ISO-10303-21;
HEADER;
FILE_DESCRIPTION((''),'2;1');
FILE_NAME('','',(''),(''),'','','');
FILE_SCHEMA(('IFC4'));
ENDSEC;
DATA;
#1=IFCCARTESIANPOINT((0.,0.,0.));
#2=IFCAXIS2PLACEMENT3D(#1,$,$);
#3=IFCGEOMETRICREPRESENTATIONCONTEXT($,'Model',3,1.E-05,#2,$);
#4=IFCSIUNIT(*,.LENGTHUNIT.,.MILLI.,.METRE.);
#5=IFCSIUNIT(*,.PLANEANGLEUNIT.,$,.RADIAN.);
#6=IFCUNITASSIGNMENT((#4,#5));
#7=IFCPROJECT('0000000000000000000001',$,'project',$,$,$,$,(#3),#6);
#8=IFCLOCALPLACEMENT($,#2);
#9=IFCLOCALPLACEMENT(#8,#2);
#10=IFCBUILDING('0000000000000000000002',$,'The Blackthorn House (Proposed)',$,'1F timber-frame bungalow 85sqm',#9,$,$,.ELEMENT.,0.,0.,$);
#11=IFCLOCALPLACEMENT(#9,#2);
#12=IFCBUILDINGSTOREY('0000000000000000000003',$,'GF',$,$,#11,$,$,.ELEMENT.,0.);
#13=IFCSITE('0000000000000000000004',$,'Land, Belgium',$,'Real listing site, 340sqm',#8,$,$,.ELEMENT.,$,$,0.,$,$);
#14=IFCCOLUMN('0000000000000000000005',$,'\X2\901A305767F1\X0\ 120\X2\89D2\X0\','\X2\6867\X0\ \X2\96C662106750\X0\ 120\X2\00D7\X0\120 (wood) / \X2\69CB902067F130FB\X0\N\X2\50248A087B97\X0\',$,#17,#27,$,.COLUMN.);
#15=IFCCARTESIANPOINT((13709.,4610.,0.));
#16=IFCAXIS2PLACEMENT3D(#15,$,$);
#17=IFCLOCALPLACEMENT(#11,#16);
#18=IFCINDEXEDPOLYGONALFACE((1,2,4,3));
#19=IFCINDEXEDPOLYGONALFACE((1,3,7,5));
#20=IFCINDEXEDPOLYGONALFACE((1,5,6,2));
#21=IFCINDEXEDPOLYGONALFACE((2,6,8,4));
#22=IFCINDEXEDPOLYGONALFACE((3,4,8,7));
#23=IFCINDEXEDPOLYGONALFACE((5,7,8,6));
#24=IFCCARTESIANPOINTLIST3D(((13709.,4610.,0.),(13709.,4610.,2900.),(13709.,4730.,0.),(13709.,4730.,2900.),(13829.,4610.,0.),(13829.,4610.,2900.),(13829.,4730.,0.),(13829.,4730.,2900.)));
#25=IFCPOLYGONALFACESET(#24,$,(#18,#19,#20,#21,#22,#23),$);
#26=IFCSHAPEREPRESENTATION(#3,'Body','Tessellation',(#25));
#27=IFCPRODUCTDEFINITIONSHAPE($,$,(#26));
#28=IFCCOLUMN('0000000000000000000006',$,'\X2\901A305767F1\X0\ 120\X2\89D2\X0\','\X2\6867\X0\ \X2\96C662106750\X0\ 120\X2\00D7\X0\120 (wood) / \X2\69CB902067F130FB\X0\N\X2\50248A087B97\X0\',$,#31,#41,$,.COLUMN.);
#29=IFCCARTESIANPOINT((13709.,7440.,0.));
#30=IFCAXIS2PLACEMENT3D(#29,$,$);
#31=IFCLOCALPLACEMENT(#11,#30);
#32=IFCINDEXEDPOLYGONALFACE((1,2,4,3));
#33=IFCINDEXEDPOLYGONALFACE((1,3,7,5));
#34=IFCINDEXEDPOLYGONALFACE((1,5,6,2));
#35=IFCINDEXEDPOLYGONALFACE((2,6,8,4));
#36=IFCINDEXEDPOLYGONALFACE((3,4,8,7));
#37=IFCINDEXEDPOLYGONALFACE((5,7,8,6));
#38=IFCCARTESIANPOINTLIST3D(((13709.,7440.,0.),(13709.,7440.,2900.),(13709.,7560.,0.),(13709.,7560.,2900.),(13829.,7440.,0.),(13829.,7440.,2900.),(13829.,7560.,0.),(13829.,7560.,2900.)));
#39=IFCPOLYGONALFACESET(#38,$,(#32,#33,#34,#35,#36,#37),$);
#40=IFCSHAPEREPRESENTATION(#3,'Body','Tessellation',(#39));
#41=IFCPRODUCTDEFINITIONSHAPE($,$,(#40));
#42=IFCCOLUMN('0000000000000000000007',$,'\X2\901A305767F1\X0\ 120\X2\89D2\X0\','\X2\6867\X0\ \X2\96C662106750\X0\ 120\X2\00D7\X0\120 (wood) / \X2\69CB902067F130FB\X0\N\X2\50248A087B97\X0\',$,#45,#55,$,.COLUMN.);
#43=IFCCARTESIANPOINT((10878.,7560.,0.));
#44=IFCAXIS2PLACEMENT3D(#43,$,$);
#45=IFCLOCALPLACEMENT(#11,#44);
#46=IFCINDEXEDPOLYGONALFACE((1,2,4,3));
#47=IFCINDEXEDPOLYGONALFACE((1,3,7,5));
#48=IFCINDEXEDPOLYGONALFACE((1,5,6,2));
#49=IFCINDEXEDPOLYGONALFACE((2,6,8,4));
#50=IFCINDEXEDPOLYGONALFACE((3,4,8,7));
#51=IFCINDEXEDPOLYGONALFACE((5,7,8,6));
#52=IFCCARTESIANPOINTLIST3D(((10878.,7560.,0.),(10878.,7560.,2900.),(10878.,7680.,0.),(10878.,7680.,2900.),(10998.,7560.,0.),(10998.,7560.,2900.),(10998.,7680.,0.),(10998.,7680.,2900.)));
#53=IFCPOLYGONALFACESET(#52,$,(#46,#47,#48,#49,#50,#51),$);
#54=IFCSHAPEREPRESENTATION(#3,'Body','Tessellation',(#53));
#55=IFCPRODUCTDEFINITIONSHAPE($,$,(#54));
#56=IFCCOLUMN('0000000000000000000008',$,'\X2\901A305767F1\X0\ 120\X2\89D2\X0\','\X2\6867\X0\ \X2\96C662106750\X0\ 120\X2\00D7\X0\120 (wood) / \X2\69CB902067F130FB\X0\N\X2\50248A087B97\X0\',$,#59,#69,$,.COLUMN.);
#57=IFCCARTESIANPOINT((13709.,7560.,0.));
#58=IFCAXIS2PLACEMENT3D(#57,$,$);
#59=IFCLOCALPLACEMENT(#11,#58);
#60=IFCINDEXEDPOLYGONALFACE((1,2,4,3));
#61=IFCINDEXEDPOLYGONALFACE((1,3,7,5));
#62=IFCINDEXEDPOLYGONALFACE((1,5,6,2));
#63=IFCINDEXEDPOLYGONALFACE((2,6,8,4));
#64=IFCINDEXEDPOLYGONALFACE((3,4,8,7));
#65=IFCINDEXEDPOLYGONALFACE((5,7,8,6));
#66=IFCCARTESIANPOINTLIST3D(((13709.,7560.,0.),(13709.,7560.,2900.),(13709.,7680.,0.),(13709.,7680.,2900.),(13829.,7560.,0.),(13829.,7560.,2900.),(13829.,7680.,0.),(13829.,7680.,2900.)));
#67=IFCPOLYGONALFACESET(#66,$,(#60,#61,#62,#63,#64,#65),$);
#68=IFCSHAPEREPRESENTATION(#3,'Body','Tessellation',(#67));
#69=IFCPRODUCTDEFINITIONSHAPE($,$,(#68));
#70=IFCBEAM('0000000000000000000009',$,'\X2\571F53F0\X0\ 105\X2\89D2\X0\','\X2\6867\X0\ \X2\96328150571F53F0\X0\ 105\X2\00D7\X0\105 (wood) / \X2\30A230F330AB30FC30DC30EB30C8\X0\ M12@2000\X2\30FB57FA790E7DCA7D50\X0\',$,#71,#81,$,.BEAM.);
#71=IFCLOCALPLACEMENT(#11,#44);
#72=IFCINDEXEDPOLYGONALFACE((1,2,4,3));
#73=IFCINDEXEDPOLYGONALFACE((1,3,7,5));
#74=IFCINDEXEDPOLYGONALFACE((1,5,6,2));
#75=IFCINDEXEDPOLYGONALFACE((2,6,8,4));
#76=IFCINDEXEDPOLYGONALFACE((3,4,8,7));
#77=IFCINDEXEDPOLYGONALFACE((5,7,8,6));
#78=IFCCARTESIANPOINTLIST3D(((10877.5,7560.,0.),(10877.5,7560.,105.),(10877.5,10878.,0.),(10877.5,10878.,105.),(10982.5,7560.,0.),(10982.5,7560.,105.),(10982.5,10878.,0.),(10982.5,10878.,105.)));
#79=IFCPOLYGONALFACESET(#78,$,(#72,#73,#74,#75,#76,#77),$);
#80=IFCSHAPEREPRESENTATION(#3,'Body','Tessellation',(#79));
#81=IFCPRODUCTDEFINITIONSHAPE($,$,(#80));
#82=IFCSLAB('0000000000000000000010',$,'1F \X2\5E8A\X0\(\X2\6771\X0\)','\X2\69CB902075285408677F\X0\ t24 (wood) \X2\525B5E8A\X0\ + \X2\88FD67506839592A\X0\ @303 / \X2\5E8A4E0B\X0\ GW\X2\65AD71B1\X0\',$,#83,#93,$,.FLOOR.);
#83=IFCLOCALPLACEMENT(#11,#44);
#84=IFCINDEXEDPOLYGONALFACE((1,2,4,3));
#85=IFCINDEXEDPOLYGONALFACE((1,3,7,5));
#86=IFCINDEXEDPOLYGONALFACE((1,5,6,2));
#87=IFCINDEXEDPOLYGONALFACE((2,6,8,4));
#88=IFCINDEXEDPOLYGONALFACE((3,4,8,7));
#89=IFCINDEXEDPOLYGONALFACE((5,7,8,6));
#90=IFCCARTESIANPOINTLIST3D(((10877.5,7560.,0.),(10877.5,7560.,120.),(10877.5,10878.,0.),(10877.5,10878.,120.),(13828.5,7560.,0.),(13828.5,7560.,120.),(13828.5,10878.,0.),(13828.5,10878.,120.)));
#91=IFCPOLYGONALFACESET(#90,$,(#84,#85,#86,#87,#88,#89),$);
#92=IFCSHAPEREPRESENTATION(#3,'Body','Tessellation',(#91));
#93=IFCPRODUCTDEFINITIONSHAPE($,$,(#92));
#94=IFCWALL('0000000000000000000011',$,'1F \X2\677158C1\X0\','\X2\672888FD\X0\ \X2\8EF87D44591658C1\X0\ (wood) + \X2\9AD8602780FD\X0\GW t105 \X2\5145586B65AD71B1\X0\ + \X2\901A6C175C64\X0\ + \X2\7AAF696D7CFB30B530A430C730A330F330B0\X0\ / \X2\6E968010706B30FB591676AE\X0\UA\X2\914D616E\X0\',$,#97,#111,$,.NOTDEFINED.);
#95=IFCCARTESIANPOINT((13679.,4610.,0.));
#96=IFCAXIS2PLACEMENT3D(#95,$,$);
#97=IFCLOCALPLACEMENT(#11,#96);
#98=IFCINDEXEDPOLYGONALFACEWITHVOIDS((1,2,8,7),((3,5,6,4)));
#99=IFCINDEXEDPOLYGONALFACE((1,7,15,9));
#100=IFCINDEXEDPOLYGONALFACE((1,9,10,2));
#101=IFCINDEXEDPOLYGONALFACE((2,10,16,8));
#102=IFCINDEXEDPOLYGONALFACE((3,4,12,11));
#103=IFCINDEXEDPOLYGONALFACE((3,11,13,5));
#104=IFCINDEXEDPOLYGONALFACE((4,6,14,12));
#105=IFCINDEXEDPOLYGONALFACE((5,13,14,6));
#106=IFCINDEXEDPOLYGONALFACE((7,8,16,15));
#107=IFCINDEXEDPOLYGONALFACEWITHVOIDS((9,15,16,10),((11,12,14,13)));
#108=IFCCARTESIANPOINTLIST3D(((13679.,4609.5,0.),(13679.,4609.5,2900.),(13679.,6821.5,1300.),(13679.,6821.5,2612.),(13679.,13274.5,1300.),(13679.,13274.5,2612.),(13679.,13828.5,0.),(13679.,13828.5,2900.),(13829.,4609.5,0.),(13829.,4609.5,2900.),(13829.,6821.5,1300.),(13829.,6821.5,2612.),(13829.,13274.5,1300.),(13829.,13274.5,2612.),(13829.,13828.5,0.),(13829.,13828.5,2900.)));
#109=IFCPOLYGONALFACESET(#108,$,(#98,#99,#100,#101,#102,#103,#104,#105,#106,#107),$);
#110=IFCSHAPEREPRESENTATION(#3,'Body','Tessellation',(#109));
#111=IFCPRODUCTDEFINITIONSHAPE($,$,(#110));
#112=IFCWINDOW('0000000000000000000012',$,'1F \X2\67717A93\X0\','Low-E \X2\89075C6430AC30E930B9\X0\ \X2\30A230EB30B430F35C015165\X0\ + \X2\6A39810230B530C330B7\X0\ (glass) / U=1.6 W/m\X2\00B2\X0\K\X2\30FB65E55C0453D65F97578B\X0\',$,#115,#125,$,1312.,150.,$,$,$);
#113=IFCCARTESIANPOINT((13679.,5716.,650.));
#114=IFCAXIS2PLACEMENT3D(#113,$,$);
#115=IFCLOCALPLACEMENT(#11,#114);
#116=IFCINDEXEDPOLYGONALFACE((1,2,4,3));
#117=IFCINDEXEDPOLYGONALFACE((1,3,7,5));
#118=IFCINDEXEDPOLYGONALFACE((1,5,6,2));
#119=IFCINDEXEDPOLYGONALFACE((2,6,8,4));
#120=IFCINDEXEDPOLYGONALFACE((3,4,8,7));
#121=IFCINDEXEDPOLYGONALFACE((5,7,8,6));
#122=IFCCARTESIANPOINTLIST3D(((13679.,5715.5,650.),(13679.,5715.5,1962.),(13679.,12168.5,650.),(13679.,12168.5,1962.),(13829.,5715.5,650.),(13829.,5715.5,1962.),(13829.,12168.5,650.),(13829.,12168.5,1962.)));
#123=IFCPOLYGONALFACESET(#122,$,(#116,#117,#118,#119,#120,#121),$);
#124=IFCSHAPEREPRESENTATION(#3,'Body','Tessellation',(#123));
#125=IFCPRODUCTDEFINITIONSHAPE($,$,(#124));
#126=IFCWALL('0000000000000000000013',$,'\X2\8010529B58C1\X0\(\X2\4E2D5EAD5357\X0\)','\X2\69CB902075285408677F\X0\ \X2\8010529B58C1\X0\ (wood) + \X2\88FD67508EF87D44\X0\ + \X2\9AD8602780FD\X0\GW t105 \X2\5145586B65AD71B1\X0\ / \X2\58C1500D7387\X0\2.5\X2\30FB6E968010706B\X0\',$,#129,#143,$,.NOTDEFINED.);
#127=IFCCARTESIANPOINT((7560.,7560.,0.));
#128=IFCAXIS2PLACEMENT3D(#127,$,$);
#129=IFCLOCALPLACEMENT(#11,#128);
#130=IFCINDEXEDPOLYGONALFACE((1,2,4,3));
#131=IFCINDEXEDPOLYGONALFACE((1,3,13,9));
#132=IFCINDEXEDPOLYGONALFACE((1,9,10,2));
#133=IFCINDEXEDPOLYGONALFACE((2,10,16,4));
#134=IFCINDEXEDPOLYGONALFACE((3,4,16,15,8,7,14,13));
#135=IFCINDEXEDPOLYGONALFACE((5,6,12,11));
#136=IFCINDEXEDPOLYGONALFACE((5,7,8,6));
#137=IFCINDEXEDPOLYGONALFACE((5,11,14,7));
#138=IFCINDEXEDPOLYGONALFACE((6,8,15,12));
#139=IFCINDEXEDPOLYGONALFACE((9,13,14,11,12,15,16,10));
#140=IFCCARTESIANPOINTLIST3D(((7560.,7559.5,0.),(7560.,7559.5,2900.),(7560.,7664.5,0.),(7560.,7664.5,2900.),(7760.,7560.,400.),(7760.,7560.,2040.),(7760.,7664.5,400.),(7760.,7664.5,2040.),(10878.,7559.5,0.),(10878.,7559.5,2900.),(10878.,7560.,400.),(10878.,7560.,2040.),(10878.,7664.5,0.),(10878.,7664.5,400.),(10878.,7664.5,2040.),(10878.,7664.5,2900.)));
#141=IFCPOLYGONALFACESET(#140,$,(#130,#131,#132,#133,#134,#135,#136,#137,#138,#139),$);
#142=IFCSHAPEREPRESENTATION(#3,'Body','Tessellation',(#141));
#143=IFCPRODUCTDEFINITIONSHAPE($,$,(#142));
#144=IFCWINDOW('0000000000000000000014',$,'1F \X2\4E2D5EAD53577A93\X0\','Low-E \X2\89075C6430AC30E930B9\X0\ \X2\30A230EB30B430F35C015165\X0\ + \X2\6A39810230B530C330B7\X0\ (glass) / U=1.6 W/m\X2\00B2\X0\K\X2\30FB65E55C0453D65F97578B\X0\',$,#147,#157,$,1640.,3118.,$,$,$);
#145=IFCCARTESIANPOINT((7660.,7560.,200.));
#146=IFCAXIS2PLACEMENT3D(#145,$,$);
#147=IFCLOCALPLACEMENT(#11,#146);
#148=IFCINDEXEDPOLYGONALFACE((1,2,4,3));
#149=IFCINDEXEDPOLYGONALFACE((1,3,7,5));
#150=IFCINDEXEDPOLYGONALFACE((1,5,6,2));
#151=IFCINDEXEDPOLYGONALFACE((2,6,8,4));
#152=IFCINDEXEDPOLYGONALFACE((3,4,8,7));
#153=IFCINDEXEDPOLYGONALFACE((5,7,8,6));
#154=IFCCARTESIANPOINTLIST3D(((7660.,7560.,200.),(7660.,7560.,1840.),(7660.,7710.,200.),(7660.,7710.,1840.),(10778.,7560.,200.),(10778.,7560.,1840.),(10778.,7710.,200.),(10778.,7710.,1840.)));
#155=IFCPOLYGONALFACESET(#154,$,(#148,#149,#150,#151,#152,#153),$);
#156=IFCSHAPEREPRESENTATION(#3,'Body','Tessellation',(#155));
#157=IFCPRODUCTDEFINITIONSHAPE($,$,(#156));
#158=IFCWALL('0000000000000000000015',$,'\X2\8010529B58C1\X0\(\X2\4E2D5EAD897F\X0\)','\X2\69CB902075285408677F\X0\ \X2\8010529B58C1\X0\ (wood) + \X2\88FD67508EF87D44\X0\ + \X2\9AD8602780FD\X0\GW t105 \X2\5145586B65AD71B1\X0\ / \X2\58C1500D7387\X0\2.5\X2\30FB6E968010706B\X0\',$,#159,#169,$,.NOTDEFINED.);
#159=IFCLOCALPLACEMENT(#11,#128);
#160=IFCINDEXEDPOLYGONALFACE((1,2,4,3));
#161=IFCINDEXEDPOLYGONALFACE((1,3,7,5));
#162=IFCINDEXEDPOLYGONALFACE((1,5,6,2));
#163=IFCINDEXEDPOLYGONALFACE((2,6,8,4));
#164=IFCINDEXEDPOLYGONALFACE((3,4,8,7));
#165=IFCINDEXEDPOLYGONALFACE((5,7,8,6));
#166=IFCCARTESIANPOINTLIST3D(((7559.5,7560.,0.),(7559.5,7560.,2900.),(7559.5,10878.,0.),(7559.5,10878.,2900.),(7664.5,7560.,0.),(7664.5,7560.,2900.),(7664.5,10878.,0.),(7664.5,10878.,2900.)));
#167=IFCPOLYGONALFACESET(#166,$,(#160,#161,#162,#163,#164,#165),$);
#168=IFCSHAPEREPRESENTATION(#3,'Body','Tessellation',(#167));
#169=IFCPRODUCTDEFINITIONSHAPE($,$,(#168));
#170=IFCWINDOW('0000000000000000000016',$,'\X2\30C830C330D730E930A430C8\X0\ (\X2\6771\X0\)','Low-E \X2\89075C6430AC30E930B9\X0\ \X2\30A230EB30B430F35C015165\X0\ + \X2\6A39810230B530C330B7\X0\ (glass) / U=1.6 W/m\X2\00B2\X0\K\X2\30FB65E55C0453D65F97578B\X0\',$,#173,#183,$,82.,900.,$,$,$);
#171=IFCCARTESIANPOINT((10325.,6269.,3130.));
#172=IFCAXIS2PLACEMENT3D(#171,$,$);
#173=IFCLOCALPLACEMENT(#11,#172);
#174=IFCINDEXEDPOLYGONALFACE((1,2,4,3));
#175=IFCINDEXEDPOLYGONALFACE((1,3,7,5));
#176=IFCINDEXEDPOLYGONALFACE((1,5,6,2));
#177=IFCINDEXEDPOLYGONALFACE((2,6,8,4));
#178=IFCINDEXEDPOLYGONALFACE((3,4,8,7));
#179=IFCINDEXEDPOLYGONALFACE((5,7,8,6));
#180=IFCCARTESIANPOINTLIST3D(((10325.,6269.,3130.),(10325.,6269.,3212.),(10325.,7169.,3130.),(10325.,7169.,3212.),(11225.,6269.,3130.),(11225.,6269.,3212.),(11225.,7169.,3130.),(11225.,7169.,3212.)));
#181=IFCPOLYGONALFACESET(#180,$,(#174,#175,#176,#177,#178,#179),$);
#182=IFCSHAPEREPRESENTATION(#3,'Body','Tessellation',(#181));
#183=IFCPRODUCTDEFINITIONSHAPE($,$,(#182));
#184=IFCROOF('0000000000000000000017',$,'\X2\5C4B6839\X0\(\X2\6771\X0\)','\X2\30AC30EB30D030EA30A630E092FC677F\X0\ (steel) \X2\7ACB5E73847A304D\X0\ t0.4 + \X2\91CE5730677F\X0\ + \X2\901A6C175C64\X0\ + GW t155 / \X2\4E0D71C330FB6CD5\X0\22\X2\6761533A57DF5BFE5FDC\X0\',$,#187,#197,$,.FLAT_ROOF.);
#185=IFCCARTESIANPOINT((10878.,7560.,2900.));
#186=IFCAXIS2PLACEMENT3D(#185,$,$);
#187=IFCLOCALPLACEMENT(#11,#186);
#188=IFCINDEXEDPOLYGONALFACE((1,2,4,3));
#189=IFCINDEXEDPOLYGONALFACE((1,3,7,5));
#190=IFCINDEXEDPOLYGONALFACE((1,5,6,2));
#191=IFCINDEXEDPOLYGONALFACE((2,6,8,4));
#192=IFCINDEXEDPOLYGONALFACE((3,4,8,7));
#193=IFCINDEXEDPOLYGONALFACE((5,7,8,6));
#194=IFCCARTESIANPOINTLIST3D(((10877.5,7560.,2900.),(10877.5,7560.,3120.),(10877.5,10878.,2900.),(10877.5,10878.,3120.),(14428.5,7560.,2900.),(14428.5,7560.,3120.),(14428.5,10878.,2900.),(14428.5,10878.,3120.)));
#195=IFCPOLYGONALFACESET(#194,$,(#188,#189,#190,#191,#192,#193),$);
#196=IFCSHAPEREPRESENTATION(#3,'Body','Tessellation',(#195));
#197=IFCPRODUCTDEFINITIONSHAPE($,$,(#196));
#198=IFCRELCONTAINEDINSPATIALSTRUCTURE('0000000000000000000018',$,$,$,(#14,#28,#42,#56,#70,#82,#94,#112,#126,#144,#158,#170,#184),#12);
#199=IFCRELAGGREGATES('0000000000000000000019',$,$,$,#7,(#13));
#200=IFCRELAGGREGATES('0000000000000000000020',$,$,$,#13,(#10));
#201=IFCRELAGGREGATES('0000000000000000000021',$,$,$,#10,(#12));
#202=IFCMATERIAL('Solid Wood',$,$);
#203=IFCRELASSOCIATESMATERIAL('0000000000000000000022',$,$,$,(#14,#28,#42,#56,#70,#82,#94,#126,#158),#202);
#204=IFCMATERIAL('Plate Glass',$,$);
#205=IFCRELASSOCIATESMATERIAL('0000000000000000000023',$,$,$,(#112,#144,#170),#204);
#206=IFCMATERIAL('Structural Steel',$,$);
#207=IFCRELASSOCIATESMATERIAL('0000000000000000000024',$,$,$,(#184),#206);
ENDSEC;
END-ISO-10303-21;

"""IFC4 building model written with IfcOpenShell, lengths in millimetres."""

from ifc_helpers import new_model, si_unit, frame, frame_2d, origin, place, context, project, spatial, rectangle, extrude, material, element, fill, save


model = new_model("IFC4")

# Units and contexts
model_context = context("Model", 3, precision=1e-05, world=origin())
ifc_project = project(units=[si_unit("LENGTHUNIT", "METRE", prefix="MILLI"), si_unit("PLANEANGLEUNIT", "RADIAN")], contexts=[model_context])

# Site, building, storey
site_placement = place(None, origin())
site = spatial("IfcSite", under=ifc_project, at=site_placement, Name="Land, Belgium", ObjectType="Real listing site, 340sqm", CompositionType="ELEMENT", RefElevation=0.0)
building_placement = place(site_placement, origin())
building = spatial("IfcBuilding", under=site, at=building_placement, Name="The Blackthorn House (Proposed)", ObjectType="1F timber-frame bungalow 85sqm", CompositionType="ELEMENT", ElevationOfRefHeight=0.0, ElevationOfTerrain=0.0)
storey_placement = place(building_placement, origin())
storey = spatial("IfcBuildingStorey", under=building, at=storey_placement, Name="GF", CompositionType="ELEMENT", Elevation=0.0)

# Columns
ifc_material_1 = material(Name="Solid Wood")
column_1_placement = place(storey_placement, frame((13709.0, 4610.0, 0.0)))
element("IfcColumn", 1, at=column_1_placement, inside=storey, material=ifc_material_1, Name="通し柱 120角", Description="桧 集成材 120×120 (wood) / 構造柱・N値計算", PredefinedType="COLUMN", context=model_context, shape_type="SweptSolid", body=[
    extrude(rectangle(XDim=120.0, YDim=120.0, at=frame_2d((60.0, 60.0))), frame((13709.0, 4610.0, 0.0)), (0.0, 0.0, 1.0), 2900.0),
])
column_2_placement = place(storey_placement, frame((13709.0, 7440.0, 0.0)))
element("IfcColumn", 2, at=column_2_placement, inside=storey, material=ifc_material_1, Name="通し柱 120角", Description="桧 集成材 120×120 (wood) / 構造柱・N値計算", PredefinedType="COLUMN", context=model_context, shape_type="SweptSolid", body=[
    extrude(rectangle(XDim=120.0, YDim=120.0, at=frame_2d((60.0, 60.0))), frame((13709.0, 7440.0, 0.0)), (0.0, 0.0, 1.0), 2900.0),
])
column_3_placement = place(storey_placement, frame((10878.0, 7560.0, 0.0)))
element("IfcColumn", 3, at=column_3_placement, inside=storey, material=ifc_material_1, Name="通し柱 120角", Description="桧 集成材 120×120 (wood) / 構造柱・N値計算", PredefinedType="COLUMN", context=model_context, shape_type="SweptSolid", body=[
    extrude(rectangle(XDim=120.0, YDim=120.0, at=frame_2d((60.0, 60.0))), frame((10878.0, 7560.0, 0.0)), (0.0, 0.0, 1.0), 2900.0),
])
column_4_placement = place(storey_placement, frame((13709.0, 7560.0, 0.0)))
element("IfcColumn", 4, at=column_4_placement, inside=storey, material=ifc_material_1, Name="通し柱 120角", Description="桧 集成材 120×120 (wood) / 構造柱・N値計算", PredefinedType="COLUMN", context=model_context, shape_type="SweptSolid", body=[
    extrude(rectangle(XDim=120.0, YDim=120.0, at=frame_2d((60.0, 60.0))), frame((13709.0, 7560.0, 0.0)), (0.0, 0.0, 1.0), 2900.0),
])

# Beam
beam_1_placement = place(storey_placement, frame((10878.0, 7560.0, 0.0)))
element("IfcBeam", 5, at=beam_1_placement, inside=storey, material=ifc_material_1, Name="土台 105角", Description="桧 防腐土台 105×105 (wood) / アンカーボルト M12@2000・基礎緊結", PredefinedType="BEAM", context=model_context, shape_type="SweptSolid", body=[
    extrude(rectangle(XDim=105.0, YDim=3318.0, at=frame_2d((52.0, 1659.0))), frame((10878.0, 7560.0, 0.0)), (0.0, 0.0, 1.0), 105.0),
])

# Slab
slab_placement = place(storey_placement, frame((10878.0, 7560.0, 0.0)))
element("IfcSlab", 6, at=slab_placement, inside=storey, material=ifc_material_1, Name="1F 床(東)", Description="構造用合板 t24 (wood) 剛床 + 製材根太 @303 / 床下 GW断熱", PredefinedType="FLOOR", context=model_context, shape_type="SweptSolid", body=[
    extrude(rectangle(XDim=2951.0, YDim=3318.0, at=frame_2d((1475.0, 1659.0))), frame((10878.0, 7560.0, 0.0)), (0.0, 0.0, 1.0), 120.0),
])

# Walls, openings, windows
wall_1_placement = place(storey_placement, frame((13679.0, 4610.0, 0.0)))
wall_1 = element("IfcWall", 7, at=wall_1_placement, inside=storey, material=ifc_material_1, Name="1F 東壁", Description="木製 軸組外壁 (wood) + 高性能GW t105 充填断熱 + 通気層 + 窯業系サイディング / 準耐火・外皮UA配慮", PredefinedType="NOTDEFINED", context=model_context, shape_type="SweptSolid", body=[
    extrude(rectangle(XDim=150.0, YDim=9219.0, at=frame_2d((75.0, 4609.0))), frame((13679.0, 4610.0, 0.0)), (0.0, 0.0, 1.0), 2900.0),
])
opening_1_placement = place(storey_placement, frame((13679.0, 5716.0, 650.0)))
opening_1 = element("IfcOpeningElement", 8, at=opening_1_placement, cuts=wall_1, PredefinedType="NOTDEFINED", context=model_context, shape_type="SweptSolid", body=[
    extrude(rectangle(XDim=150.0, YDim=6453.0, at=frame_2d((75.0, 3226.0))), frame((13679.0, 5716.0, 650.0)), (0.0, 0.0, 1.0), 1312.0),
])
ifc_material_2 = material(Name="Plate Glass")
window_1_placement = place(storey_placement, frame((13679.0, 5716.0, 650.0)))
window_1 = element("IfcWindow", 9, at=window_1_placement, inside=storey, material=ifc_material_2, Name="1F 東窓", Description="Low-E 複層ガラス アルゴン封入 + 樹脂サッシ (glass) / U=1.6 W/m²K・日射取得型", OverallHeight=1312.0, OverallWidth=150.0, context=model_context, shape_type="SweptSolid", body=[
    extrude(rectangle(XDim=150.0, YDim=6453.0, at=frame_2d((75.0, 3226.0))), frame((13679.0, 5716.0, 650.0)), (0.0, 0.0, 1.0), 1312.0),
])
fill(opening_1, window_1)
wall_2_placement = place(storey_placement, frame((7560.0, 7560.0, 0.0)))
wall_2 = element("IfcWall", 10, at=wall_2_placement, inside=storey, material=ifc_material_1, Name="耐力壁(中庭南)", Description="構造用合板 耐力壁 (wood) + 製材軸組 + 高性能GW t105 充填断熱 / 壁倍率2.5・準耐火", PredefinedType="NOTDEFINED", context=model_context, shape_type="SweptSolid", body=[
    extrude(rectangle(XDim=3318.0, YDim=105.0, at=frame_2d((1659.0, 52.0))), frame((7560.0, 7560.0, 0.0)), (0.0, 0.0, 1.0), 2900.0),
])
opening_2_placement = place(storey_placement, frame((7660.0, 7560.0, 200.0)))
opening_2 = element("IfcOpeningElement", 11, at=opening_2_placement, cuts=wall_2, PredefinedType="NOTDEFINED", context=model_context, shape_type="SweptSolid", body=[
    extrude(rectangle(XDim=3118.0, YDim=150.0, at=frame_2d((1559.0, 75.0))), frame((7660.0, 7560.0, 200.0)), (0.0, 0.0, 1.0), 1640.0),
])
window_2_placement = place(storey_placement, frame((7660.0, 7560.0, 200.0)))
window_2 = element("IfcWindow", 12, at=window_2_placement, inside=storey, material=ifc_material_2, Name="1F 中庭南窓", Description="Low-E 複層ガラス アルゴン封入 + 樹脂サッシ (glass) / U=1.6 W/m²K・日射取得型", OverallHeight=1640.0, OverallWidth=3118.0, context=model_context, shape_type="SweptSolid", body=[
    extrude(rectangle(XDim=3118.0, YDim=150.0, at=frame_2d((1559.0, 75.0))), frame((7660.0, 7560.0, 200.0)), (0.0, 0.0, 1.0), 1640.0),
])
fill(opening_2, window_2)

# Wall
wall_3_placement = place(storey_placement, frame((7560.0, 7560.0, 0.0)))
element("IfcWall", 13, at=wall_3_placement, inside=storey, material=ifc_material_1, Name="耐力壁(中庭西)", Description="構造用合板 耐力壁 (wood) + 製材軸組 + 高性能GW t105 充填断熱 / 壁倍率2.5・準耐火", PredefinedType="NOTDEFINED", context=model_context, shape_type="SweptSolid", body=[
    extrude(rectangle(XDim=105.0, YDim=3318.0, at=frame_2d((52.0, 1659.0))), frame((7560.0, 7560.0, 0.0)), (0.0, 0.0, 1.0), 2900.0),
])

# Window
window_3_placement = place(storey_placement, frame((10325.0, 6269.0, 3130.0)))
element("IfcWindow", 14, at=window_3_placement, inside=storey, material=ifc_material_2, Name="トップライト (東)", Description="Low-E 複層ガラス アルゴン封入 + 樹脂サッシ (glass) / U=1.6 W/m²K・日射取得型", OverallHeight=82.0, OverallWidth=900.0, context=model_context, shape_type="SweptSolid", body=[
    extrude(rectangle(XDim=900.0, YDim=900.0, at=frame_2d((450.0, 450.0))), frame((10325.0, 6269.0, 3130.0)), (0.0, 0.0, 1.0), 82.0),
])

# Roof
ifc_material_3 = material(Name="Structural Steel")
roof_placement = place(storey_placement, frame((10878.0, 7560.0, 2900.0)))
element("IfcRoof", 15, at=roof_placement, inside=storey, material=ifc_material_3, Name="屋根(東)", Description="ガルバリウム鋼板 (steel) 立平葺き t0.4 + 野地板 + 通気層 + GW t155 / 不燃・法22条区域対応", PredefinedType="FLAT_ROOF", context=model_context, shape_type="SweptSolid", body=[
    extrude(rectangle(XDim=3551.0, YDim=3318.0, at=frame_2d((1775.0, 1659.0))), frame((10878.0, 7560.0, 2900.0)), (0.0, 0.0, 1.0), 220.0),
])

save(model, "model.ifc")
